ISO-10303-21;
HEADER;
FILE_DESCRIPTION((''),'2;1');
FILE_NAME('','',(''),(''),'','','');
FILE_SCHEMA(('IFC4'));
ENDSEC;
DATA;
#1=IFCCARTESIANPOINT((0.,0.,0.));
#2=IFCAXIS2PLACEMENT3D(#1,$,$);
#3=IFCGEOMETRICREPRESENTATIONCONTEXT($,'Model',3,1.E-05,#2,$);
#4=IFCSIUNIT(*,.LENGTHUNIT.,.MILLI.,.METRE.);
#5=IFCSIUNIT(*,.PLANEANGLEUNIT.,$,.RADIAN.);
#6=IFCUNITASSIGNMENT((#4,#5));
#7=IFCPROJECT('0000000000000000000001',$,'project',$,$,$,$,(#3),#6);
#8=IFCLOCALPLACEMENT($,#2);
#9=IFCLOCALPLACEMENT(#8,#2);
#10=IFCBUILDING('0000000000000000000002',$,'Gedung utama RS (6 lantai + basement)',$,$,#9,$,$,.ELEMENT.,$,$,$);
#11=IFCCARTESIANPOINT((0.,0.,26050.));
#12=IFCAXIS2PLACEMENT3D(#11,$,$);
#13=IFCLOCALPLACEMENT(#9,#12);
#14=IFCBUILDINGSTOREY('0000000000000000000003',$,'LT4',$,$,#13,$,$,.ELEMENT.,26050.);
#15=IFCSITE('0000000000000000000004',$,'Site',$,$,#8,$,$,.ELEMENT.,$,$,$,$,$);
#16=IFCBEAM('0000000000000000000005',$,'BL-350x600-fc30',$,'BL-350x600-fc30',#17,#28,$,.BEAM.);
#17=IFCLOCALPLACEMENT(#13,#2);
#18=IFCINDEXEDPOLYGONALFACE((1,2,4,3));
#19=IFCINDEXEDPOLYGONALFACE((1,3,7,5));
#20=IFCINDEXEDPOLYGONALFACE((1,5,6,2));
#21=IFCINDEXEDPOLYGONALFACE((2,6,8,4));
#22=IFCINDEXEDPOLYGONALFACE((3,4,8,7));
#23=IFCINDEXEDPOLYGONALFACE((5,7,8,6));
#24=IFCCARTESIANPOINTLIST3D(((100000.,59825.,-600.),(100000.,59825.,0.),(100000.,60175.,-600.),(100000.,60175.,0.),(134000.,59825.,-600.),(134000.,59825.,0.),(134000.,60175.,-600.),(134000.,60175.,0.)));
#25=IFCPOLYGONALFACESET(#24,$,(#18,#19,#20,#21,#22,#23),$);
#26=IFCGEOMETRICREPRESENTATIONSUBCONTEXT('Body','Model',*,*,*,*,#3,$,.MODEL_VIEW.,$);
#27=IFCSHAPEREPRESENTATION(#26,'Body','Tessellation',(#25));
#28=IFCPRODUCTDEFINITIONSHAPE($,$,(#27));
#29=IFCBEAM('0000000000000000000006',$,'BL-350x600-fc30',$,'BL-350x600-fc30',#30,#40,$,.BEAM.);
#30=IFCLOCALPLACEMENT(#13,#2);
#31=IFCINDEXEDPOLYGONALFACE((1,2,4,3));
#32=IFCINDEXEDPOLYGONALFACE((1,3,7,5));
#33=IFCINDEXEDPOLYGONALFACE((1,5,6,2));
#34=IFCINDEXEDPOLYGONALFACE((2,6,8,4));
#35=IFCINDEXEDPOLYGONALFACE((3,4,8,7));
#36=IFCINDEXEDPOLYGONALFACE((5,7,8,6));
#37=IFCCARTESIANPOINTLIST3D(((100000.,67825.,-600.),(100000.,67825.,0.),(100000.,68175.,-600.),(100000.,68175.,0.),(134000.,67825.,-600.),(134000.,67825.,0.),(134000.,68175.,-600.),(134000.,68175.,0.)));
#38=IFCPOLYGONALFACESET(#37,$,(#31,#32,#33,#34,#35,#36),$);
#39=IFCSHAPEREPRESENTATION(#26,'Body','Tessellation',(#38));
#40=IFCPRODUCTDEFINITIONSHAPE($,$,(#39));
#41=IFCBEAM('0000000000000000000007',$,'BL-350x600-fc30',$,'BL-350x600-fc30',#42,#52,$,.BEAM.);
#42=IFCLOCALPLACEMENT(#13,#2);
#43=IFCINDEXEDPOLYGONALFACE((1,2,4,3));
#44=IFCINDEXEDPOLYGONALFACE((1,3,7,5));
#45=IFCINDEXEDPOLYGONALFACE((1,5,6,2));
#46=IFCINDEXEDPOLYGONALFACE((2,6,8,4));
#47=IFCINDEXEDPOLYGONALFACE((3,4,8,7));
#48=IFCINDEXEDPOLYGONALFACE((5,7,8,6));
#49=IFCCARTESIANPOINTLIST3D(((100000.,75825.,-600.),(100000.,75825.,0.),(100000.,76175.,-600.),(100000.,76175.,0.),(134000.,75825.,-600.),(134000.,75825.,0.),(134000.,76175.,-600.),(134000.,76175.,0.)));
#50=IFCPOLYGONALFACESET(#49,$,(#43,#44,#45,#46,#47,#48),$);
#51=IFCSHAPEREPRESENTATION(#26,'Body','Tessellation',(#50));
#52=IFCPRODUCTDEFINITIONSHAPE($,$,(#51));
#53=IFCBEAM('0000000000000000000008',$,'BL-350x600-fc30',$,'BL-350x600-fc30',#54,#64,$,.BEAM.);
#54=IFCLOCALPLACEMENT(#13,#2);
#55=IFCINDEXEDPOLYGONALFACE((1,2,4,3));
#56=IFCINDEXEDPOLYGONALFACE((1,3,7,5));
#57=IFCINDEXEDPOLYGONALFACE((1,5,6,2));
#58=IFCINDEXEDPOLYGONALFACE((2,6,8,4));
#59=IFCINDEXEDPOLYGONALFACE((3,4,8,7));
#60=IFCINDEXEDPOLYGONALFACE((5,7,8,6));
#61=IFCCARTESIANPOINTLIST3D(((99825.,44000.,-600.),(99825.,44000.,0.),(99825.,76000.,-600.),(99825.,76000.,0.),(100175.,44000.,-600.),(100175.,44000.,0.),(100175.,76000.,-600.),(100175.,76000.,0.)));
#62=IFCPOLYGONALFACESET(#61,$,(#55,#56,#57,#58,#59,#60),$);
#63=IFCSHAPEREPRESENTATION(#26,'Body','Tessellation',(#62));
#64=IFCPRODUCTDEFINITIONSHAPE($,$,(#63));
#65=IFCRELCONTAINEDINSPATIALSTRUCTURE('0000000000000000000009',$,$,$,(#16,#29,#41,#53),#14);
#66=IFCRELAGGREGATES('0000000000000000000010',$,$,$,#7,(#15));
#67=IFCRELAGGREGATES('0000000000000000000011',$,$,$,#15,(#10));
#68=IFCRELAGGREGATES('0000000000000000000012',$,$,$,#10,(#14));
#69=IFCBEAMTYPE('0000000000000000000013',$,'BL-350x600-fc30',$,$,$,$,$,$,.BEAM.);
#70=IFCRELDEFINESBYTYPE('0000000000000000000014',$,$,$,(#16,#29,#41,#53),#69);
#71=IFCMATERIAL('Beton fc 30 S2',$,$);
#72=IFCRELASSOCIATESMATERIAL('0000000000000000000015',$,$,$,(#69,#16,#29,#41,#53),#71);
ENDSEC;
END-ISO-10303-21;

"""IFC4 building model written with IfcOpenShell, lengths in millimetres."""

from ifc_helpers import new_model, si_unit, frame, origin, origin_2d, place, context, subcontext, project, spatial, rectangle, extrude, material, material_profile, profile_set, profile_usage, type_object, element, save


model = new_model("IFC4")

# Units and contexts
model_context = context("Model", 3, precision=1e-05, world=origin())
body_context = subcontext(model_context, "Body", "Model", "MODEL_VIEW")
ifc_project = project(units=[si_unit("LENGTHUNIT", "METRE", prefix="MILLI"), si_unit("PLANEANGLEUNIT", "RADIAN")], contexts=[model_context])

# Site, building, storey
site_placement = place(None, origin())
site = spatial("IfcSite", under=ifc_project, at=site_placement, Name="Site", CompositionType="ELEMENT")
building_placement = place(site_placement, origin())
building = spatial("IfcBuilding", under=site, at=building_placement, Name="Gedung utama RS (6 lantai + basement)", CompositionType="ELEMENT")
storey_placement = place(building_placement, frame((0.0, 0.0, 26050.0)))
storey = spatial("IfcBuildingStorey", under=building, at=storey_placement, Name="LT4", CompositionType="ELEMENT", Elevation=26050.0)

# Beams
ifc_material = material(Name="Beton fc 30 S2")
ifc_material_profile_1 = material_profile(ifc_material, rectangle(XDim=350.0, YDim=600.0, at=origin_2d()), Name="BL-350x600-fc30")
ifc_profile_set_1 = profile_set([ifc_material_profile_1], Name="BL-350x600-fc30")
ifc_profile_usage_1 = profile_usage(ifc_profile_set_1, cardinal=8)
beam_type = type_object("IfcBeamType", Name="BL-350x600-fc30", PredefinedType="BEAM", material=ifc_profile_set_1)
for number, where, name in (
    (1, (100000.0, 60000.0, -300.0), "BL-350x600-fc30"),
    (2, (100000.0, 68000.0, -300.0), "BL-350x600-fc30"),
    (3, (100000.0, 76000.0, -300.0), "BL-350x600-fc30"),
):
    element("IfcBeam", number, at=place(storey_placement, frame(where)), inside=storey, type_object=beam_type, material=ifc_profile_usage_1, Name=name, ObjectType="BL-350x600-fc30", PredefinedType="BEAM", context=body_context, shape_type="SweptSolid", body=[
        extrude(rectangle(XDim=350.0, YDim=600.0, at=origin_2d()), frame((0.0, 0.0, 0.0), z_axis=(1.0, 0.0, 0.0), x_axis=(0.0, 1.0, 0.0)), (0.0, 0.0, 1.0), 34000.0),
    ])
beam_placement = place(storey_placement, frame((100000.0, 44000.0, -300.0)))
element("IfcBeam", 4, at=beam_placement, inside=storey, type_object=beam_type, material=ifc_profile_usage_1, Name="BL-350x600-fc30", ObjectType="BL-350x600-fc30", PredefinedType="BEAM", context=body_context, shape_type="SweptSolid", body=[
    extrude(rectangle(XDim=350.0, YDim=600.0, at=origin_2d()), frame((0.0, 0.0, 0.0), z_axis=(0.0, 1.0, 0.0), x_axis=(-1.0, 0.0, 0.0)), (0.0, 0.0, 1.0), 32000.0),
])

save(model, "model.ifc")
